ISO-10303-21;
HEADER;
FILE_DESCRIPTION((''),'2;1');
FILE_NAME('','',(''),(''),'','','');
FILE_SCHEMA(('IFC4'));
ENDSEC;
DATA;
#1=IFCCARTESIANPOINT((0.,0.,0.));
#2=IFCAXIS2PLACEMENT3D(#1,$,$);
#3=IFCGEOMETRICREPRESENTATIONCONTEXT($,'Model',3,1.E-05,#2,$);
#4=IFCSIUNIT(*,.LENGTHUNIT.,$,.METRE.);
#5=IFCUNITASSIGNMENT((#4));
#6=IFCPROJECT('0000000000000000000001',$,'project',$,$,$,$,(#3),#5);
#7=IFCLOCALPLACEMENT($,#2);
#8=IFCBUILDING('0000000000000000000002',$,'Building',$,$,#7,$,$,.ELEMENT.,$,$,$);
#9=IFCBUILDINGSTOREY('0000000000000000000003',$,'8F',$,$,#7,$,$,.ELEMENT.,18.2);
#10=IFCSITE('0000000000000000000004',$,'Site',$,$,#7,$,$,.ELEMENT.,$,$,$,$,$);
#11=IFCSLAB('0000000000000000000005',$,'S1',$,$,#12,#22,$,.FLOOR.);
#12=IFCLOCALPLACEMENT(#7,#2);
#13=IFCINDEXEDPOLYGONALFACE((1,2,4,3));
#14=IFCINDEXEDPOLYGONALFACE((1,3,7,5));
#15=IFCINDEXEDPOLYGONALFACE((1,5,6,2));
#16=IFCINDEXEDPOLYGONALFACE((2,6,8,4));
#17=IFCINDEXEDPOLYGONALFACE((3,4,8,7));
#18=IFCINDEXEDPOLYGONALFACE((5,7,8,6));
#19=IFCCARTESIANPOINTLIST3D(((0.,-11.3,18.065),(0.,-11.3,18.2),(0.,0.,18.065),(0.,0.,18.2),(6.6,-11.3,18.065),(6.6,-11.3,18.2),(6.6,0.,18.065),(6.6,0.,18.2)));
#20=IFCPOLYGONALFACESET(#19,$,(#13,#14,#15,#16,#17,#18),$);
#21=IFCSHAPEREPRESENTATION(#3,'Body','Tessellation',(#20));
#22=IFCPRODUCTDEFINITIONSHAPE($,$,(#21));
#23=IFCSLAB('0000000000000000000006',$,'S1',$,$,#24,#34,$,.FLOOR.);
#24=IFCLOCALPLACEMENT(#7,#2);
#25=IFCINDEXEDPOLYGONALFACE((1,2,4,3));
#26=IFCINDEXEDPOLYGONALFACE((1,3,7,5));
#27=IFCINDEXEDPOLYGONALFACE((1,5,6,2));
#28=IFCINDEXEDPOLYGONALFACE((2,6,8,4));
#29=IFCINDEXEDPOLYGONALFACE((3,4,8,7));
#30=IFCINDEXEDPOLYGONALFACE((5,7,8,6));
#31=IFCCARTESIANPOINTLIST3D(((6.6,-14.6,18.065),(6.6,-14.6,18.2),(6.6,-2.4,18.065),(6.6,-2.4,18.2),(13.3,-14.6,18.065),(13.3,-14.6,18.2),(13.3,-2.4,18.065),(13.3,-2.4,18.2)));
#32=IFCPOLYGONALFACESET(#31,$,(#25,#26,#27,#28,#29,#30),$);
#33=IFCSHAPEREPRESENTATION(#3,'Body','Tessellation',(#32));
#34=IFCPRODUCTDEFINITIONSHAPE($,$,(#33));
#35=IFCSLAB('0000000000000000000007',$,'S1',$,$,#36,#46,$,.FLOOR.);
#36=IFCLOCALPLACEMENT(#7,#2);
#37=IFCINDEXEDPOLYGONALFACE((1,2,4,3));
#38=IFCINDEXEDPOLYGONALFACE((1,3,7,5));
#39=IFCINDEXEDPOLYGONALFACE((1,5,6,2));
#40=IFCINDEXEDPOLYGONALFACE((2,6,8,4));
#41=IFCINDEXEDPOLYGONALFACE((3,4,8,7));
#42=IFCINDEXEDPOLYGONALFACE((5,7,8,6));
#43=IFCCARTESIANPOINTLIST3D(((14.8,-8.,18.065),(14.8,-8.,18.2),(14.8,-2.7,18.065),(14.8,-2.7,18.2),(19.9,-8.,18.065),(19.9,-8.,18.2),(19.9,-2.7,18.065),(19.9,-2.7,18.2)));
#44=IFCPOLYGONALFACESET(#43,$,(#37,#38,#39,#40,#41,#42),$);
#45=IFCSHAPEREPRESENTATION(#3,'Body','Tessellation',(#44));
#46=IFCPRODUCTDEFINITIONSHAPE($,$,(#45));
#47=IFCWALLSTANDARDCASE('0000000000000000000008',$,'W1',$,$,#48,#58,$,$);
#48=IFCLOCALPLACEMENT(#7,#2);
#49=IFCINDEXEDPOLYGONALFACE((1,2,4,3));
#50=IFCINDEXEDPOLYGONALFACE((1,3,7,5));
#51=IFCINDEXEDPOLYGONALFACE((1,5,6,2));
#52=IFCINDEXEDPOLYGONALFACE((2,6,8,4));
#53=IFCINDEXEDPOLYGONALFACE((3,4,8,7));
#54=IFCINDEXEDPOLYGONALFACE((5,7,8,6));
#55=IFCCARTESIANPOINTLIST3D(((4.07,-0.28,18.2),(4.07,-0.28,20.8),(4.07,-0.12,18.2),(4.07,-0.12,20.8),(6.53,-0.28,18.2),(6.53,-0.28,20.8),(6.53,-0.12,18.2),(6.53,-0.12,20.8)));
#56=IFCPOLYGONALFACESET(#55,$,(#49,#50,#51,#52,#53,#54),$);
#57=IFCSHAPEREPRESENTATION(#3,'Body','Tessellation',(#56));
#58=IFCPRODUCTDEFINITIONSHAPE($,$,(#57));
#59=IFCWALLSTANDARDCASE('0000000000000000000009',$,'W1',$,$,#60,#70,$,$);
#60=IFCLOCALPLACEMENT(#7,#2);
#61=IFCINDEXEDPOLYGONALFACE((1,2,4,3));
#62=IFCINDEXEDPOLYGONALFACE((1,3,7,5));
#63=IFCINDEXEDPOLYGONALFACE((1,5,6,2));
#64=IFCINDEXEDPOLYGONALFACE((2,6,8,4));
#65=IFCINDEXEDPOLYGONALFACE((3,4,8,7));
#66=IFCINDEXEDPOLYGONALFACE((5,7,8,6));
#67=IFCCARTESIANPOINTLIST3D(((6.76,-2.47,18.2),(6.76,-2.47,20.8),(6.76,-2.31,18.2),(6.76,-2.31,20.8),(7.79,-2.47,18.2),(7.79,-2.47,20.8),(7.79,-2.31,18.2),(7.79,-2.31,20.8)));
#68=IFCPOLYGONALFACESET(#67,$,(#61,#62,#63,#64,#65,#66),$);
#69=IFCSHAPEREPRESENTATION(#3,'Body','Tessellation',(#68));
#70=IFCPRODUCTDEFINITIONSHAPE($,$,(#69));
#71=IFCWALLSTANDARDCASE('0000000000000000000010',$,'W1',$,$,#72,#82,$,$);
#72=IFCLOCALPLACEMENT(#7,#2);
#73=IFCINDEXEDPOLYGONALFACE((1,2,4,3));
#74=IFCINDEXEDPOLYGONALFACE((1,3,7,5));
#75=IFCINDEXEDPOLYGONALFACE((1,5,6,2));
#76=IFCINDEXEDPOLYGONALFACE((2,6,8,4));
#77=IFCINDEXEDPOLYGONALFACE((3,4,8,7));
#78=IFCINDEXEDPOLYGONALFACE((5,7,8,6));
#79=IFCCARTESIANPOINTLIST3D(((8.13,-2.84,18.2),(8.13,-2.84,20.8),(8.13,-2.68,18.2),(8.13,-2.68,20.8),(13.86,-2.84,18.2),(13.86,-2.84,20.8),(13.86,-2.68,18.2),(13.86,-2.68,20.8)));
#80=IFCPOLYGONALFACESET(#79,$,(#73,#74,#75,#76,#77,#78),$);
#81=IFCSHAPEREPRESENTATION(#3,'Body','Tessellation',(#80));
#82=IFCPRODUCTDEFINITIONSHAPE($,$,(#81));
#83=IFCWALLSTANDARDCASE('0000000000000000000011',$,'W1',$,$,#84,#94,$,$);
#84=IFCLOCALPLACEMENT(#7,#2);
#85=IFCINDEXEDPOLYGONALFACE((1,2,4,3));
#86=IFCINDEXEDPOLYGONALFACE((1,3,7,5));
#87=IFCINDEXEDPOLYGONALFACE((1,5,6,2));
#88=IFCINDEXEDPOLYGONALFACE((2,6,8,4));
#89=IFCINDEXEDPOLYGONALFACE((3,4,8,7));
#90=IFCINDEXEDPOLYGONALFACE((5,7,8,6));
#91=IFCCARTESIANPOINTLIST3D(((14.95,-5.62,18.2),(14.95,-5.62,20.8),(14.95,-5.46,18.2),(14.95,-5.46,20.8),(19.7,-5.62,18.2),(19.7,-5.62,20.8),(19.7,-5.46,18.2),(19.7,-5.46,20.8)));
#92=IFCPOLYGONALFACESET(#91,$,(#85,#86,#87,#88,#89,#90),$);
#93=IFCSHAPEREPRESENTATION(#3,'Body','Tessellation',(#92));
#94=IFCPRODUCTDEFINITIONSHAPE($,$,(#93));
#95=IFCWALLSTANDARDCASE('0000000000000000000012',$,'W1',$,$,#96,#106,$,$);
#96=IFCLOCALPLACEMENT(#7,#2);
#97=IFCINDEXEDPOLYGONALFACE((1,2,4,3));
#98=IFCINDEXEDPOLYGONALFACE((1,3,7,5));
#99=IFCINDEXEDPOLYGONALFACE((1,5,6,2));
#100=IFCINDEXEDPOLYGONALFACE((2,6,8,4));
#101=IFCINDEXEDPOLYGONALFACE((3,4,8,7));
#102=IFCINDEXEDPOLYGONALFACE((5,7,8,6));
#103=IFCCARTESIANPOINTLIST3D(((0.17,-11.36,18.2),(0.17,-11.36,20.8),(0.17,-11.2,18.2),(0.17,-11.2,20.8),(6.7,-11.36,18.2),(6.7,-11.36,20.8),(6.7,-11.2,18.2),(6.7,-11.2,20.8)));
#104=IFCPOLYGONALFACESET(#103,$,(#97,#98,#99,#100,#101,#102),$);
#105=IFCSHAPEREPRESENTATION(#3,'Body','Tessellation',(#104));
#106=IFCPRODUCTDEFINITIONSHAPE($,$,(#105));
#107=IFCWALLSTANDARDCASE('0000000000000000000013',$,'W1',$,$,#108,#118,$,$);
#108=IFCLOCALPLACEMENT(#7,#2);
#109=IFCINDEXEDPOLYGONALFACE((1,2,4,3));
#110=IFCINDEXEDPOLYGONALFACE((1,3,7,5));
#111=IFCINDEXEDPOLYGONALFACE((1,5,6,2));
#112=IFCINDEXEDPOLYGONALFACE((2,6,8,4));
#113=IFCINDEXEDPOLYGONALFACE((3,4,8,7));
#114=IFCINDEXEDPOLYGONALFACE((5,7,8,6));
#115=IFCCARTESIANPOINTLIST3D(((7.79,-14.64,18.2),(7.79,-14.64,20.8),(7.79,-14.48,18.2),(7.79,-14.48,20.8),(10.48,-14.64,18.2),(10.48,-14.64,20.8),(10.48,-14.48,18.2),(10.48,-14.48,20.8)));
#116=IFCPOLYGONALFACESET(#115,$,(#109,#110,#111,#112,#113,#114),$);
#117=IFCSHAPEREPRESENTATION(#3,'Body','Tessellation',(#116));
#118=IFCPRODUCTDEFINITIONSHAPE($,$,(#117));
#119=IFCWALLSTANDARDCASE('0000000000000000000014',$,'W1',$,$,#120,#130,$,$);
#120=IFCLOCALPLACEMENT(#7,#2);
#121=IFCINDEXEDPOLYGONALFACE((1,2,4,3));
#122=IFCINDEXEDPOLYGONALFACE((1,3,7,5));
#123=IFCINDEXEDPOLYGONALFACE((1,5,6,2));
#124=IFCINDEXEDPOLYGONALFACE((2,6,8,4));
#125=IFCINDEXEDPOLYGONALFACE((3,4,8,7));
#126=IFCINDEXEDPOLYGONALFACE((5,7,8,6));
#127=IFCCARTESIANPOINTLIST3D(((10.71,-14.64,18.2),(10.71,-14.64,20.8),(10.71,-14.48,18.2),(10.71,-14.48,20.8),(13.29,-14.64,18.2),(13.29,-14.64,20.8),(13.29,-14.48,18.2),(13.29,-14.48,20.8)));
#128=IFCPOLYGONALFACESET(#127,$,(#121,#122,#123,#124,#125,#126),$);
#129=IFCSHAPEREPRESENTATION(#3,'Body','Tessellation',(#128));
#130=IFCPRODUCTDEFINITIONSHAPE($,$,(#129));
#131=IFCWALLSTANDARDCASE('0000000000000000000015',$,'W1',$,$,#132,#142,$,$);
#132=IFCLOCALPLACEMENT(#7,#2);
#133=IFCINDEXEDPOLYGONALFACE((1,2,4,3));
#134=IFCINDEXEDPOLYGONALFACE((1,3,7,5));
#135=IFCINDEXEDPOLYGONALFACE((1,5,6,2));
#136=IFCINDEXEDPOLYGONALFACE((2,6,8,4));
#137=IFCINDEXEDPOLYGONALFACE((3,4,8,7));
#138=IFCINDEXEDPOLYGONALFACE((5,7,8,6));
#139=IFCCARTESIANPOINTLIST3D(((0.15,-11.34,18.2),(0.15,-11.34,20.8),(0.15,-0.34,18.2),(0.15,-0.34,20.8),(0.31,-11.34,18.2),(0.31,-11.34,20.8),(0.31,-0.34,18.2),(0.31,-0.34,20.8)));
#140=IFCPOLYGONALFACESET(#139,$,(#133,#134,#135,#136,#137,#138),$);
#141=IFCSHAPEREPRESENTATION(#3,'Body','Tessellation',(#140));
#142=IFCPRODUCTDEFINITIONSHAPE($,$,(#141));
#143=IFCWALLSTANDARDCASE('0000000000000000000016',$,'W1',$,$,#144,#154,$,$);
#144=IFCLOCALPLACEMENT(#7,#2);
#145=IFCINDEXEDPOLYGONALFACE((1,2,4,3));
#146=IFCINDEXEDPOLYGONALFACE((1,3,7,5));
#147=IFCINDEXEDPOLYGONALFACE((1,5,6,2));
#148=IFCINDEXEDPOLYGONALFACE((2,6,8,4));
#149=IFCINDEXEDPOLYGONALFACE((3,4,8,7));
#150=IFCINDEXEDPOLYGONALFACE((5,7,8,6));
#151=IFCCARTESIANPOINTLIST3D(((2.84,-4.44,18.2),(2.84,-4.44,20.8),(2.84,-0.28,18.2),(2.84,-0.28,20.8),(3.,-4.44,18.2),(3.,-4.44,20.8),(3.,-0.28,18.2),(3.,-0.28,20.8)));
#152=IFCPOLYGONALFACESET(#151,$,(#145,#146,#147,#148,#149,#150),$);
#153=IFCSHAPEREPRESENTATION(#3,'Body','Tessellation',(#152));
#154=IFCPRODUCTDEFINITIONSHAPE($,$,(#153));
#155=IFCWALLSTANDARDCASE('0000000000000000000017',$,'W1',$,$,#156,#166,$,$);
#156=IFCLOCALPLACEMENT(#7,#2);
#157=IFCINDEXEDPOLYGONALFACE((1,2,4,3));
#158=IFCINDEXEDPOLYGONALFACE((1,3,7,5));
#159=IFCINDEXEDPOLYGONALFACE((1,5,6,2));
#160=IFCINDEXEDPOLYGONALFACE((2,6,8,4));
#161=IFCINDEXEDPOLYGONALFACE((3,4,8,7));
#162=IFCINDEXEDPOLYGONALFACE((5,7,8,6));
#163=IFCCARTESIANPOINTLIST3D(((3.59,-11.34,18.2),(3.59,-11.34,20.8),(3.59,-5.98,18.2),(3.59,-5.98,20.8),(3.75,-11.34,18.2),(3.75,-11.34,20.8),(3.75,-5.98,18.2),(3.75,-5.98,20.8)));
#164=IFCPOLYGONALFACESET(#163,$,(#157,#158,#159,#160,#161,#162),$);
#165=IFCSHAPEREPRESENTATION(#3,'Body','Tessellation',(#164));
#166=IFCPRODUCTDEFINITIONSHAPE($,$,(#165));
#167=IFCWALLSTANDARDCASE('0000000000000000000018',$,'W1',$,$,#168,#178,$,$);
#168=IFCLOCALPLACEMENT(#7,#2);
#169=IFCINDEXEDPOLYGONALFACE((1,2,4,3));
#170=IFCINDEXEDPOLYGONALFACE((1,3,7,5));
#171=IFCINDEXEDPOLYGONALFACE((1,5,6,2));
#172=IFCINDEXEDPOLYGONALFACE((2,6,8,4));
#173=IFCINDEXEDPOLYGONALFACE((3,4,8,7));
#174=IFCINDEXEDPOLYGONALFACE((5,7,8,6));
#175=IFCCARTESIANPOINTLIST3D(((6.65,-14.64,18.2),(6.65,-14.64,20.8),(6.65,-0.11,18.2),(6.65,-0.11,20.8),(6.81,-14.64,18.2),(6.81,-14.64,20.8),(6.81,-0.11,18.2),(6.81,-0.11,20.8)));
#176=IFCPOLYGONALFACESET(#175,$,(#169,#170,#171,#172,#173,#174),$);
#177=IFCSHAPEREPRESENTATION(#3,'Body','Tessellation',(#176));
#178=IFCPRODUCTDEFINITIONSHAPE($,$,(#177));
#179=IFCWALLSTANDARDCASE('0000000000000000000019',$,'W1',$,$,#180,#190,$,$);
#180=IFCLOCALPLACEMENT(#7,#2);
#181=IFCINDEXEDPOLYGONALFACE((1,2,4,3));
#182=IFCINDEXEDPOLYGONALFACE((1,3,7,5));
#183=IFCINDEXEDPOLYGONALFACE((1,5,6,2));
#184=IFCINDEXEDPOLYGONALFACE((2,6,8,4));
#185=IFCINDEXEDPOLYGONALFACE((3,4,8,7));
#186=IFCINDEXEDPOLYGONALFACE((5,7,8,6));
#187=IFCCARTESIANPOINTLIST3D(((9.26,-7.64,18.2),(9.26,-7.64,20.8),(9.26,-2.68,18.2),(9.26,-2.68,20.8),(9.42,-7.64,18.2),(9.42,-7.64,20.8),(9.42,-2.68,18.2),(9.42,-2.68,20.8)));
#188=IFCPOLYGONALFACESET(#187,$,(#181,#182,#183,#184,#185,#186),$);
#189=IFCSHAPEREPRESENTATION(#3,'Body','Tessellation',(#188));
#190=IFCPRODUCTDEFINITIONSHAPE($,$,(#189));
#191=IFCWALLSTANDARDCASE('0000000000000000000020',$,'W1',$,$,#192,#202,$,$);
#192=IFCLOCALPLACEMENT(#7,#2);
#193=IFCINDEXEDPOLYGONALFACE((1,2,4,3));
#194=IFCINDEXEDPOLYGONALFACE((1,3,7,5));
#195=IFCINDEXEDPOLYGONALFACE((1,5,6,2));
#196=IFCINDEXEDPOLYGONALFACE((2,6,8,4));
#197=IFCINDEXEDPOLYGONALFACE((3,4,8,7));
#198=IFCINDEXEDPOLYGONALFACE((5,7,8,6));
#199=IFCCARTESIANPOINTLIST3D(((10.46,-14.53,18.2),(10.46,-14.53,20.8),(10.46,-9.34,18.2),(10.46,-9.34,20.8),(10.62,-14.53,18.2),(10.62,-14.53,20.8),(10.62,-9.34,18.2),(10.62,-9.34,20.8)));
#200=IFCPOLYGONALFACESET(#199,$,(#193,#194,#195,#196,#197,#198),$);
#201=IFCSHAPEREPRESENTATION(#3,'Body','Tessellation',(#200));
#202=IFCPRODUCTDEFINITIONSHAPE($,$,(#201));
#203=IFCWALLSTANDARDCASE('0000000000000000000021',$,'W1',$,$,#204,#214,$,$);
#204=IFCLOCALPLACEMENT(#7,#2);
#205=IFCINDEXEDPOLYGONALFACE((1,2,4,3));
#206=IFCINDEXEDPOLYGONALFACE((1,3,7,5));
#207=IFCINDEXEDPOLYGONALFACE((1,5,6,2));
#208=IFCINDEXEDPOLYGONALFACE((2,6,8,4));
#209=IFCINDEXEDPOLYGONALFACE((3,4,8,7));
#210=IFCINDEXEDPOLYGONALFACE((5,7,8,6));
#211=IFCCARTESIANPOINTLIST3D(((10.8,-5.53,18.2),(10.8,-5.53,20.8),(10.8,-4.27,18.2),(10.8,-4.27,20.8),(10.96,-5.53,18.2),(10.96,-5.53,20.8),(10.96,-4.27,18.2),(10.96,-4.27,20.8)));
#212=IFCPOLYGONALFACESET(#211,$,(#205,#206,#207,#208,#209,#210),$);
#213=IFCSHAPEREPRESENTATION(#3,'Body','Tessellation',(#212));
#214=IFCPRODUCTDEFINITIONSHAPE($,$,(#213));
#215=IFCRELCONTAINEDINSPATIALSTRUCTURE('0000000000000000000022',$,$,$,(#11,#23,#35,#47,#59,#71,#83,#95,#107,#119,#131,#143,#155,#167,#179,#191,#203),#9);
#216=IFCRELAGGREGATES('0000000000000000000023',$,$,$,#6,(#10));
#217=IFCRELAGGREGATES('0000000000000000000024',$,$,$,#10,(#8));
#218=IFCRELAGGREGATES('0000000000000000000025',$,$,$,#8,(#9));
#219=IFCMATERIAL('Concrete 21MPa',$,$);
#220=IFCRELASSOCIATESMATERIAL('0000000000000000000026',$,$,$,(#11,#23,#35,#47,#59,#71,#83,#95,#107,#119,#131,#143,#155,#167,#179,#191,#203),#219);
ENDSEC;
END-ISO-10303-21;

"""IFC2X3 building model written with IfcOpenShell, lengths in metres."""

from ifc_helpers import new_model, si_unit, frame, origin, origin_2d, place, context, project, spatial, rectangle, extrude, material, element, save


model = new_model("IFC2X3")

# Units and contexts
model_context = context("Model", 3, precision=1e-05, world=origin())
ifc_project = project(units=[si_unit("LENGTHUNIT", "METRE")], contexts=[model_context])

# Site, building, storey
placement = place(None, origin())
site = spatial("IfcSite", under=ifc_project, at=placement, Name="Site", CompositionType="ELEMENT")
building = spatial("IfcBuilding", under=site, at=placement, Name="Building", CompositionType="ELEMENT")
storey = spatial("IfcBuildingStorey", under=building, at=placement, Name="8F", CompositionType="ELEMENT", Elevation=18.2)

# Slabs
ifc_material_1 = material(Name="Concrete 21MPa")
slab_1_placement = place(None, frame((3.3, -5.65, 18.065)))
element("IfcSlab", 1, at=slab_1_placement, inside=storey, material=ifc_material_1, Name="S1", PredefinedType="FLOOR", context=model_context, shape_type="SweptSolid", body=[
    extrude(rectangle(XDim=6.6, YDim=11.3, at=origin_2d()), origin(), (0.0, 0.0, 1.0), 0.135),
])
slab_2_placement = place(None, frame((9.95, -8.5, 18.065)))
element("IfcSlab", 2, at=slab_2_placement, inside=storey, material=ifc_material_1, Name="S1", PredefinedType="FLOOR", context=model_context, shape_type="SweptSolid", body=[
    extrude(rectangle(XDim=6.7, YDim=12.2, at=origin_2d()), origin(), (0.0, 0.0, 1.0), 0.135),
])
slab_3_placement = place(None, frame((17.35, -5.35, 18.065)))
element("IfcSlab", 3, at=slab_3_placement, inside=storey, material=ifc_material_1, Name="S1", PredefinedType="FLOOR", context=model_context, shape_type="SweptSolid", body=[
    extrude(rectangle(XDim=5.1, YDim=5.3, at=origin_2d()), origin(), (0.0, 0.0, 1.0), 0.135),
])

# Walls
wall_1_placement = place(None, frame((5.3, -0.2, 18.2)))
element("IfcWallStandardCase", 4, at=wall_1_placement, inside=storey, material=ifc_material_1, Name="W1", context=model_context, shape_type="SweptSolid", body=[
    extrude(rectangle(XDim=2.46, YDim=0.16, at=origin_2d()), origin(), (0.0, 0.0, 1.0), 2.6),
])
wall_2_placement = place(None, frame((7.275, -2.39, 18.2)))
element("IfcWallStandardCase", 5, at=wall_2_placement, inside=storey, material=ifc_material_1, Name="W1", context=model_context, shape_type="SweptSolid", body=[
    extrude(rectangle(XDim=1.03, YDim=0.16, at=origin_2d()), origin(), (0.0, 0.0, 1.0), 2.6),
])
wall_3_placement = place(None, frame((10.995, -2.76, 18.2)))
element("IfcWallStandardCase", 6, at=wall_3_placement, inside=storey, material=ifc_material_1, Name="W1", context=model_context, shape_type="SweptSolid", body=[
    extrude(rectangle(XDim=5.73, YDim=0.16, at=origin_2d()), origin(), (0.0, 0.0, 1.0), 2.6),
])
wall_4_placement = place(None, frame((17.325, -5.54, 18.2)))
element("IfcWallStandardCase", 7, at=wall_4_placement, inside=storey, material=ifc_material_1, Name="W1", context=model_context, shape_type="SweptSolid", body=[
    extrude(rectangle(XDim=4.75, YDim=0.16, at=origin_2d()), origin(), (0.0, 0.0, 1.0), 2.6),
])
wall_5_placement = place(None, frame((3.435, -11.28, 18.2)))
element("IfcWallStandardCase", 8, at=wall_5_placement, inside=storey, material=ifc_material_1, Name="W1", context=model_context, shape_type="SweptSolid", body=[
    extrude(rectangle(XDim=6.53, YDim=0.16, at=origin_2d()), origin(), (0.0, 0.0, 1.0), 2.6),
])
wall_6_placement = place(None, frame((9.135, -14.56, 18.2)))
element("IfcWallStandardCase", 9, at=wall_6_placement, inside=storey, material=ifc_material_1, Name="W1", context=model_context, shape_type="SweptSolid", body=[
    extrude(rectangle(XDim=2.69, YDim=0.16, at=origin_2d()), origin(), (0.0, 0.0, 1.0), 2.6),
])
wall_7_placement = place(None, frame((12.0, -14.56, 18.2)))
element("IfcWallStandardCase", 10, at=wall_7_placement, inside=storey, material=ifc_material_1, Name="W1", context=model_context, shape_type="SweptSolid", body=[
    extrude(rectangle(XDim=2.58, YDim=0.16, at=origin_2d()), origin(), (0.0, 0.0, 1.0), 2.6),
])
wall_8_placement = place(None, frame((0.23, -5.84, 18.2)))
element("IfcWallStandardCase", 11, at=wall_8_placement, inside=storey, material=ifc_material_1, Name="W1", context=model_context, shape_type="SweptSolid", body=[
    extrude(rectangle(XDim=0.16, YDim=11.0, at=origin_2d()), origin(), (0.0, 0.0, 1.0), 2.6),
])
wall_9_placement = place(None, frame((2.92, -2.36, 18.2)))
element("IfcWallStandardCase", 12, at=wall_9_placement, inside=storey, material=ifc_material_1, Name="W1", context=model_context, shape_type="SweptSolid", body=[
    extrude(rectangle(XDim=0.16, YDim=4.16, at=origin_2d()), origin(), (0.0, 0.0, 1.0), 2.6),
])
wall_10_placement = place(None, frame((3.67, -8.66, 18.2)))
element("IfcWallStandardCase", 13, at=wall_10_placement, inside=storey, material=ifc_material_1, Name="W1", context=model_context, shape_type="SweptSolid", body=[
    extrude(rectangle(XDim=0.16, YDim=5.36, at=origin_2d()), origin(), (0.0, 0.0, 1.0), 2.6),
])
wall_11_placement = place(None, frame((6.73, -7.375, 18.2)))
element("IfcWallStandardCase", 14, at=wall_11_placement, inside=storey, material=ifc_material_1, Name="W1", context=model_context, shape_type="SweptSolid", body=[
    extrude(rectangle(XDim=0.16, YDim=14.53, at=origin_2d()), origin(), (0.0, 0.0, 1.0), 2.6),
])
wall_12_placement = place(None, frame((9.34, -5.16, 18.2)))
element("IfcWallStandardCase", 15, at=wall_12_placement, inside=storey, material=ifc_material_1, Name="W1", context=model_context, shape_type="SweptSolid", body=[
    extrude(rectangle(XDim=0.16, YDim=4.96, at=origin_2d()), origin(), (0.0, 0.0, 1.0), 2.6),
])
wall_13_placement = place(None, frame((10.54, -11.935, 18.2)))
element("IfcWallStandardCase", 16, at=wall_13_placement, inside=storey, material=ifc_material_1, Name="W1", context=model_context, shape_type="SweptSolid", body=[
    extrude(rectangle(XDim=0.16, YDim=5.19, at=origin_2d()), origin(), (0.0, 0.0, 1.0), 2.6),
])
wall_14_placement = place(None, frame((10.88, -4.9, 18.2)))
element("IfcWallStandardCase", 17, at=wall_14_placement, inside=storey, material=ifc_material_1, Name="W1", context=model_context, shape_type="SweptSolid", body=[
    extrude(rectangle(XDim=0.16, YDim=1.26, at=origin_2d()), origin(), (0.0, 0.0, 1.0), 2.6),
])

save(model, "model.ifc")
